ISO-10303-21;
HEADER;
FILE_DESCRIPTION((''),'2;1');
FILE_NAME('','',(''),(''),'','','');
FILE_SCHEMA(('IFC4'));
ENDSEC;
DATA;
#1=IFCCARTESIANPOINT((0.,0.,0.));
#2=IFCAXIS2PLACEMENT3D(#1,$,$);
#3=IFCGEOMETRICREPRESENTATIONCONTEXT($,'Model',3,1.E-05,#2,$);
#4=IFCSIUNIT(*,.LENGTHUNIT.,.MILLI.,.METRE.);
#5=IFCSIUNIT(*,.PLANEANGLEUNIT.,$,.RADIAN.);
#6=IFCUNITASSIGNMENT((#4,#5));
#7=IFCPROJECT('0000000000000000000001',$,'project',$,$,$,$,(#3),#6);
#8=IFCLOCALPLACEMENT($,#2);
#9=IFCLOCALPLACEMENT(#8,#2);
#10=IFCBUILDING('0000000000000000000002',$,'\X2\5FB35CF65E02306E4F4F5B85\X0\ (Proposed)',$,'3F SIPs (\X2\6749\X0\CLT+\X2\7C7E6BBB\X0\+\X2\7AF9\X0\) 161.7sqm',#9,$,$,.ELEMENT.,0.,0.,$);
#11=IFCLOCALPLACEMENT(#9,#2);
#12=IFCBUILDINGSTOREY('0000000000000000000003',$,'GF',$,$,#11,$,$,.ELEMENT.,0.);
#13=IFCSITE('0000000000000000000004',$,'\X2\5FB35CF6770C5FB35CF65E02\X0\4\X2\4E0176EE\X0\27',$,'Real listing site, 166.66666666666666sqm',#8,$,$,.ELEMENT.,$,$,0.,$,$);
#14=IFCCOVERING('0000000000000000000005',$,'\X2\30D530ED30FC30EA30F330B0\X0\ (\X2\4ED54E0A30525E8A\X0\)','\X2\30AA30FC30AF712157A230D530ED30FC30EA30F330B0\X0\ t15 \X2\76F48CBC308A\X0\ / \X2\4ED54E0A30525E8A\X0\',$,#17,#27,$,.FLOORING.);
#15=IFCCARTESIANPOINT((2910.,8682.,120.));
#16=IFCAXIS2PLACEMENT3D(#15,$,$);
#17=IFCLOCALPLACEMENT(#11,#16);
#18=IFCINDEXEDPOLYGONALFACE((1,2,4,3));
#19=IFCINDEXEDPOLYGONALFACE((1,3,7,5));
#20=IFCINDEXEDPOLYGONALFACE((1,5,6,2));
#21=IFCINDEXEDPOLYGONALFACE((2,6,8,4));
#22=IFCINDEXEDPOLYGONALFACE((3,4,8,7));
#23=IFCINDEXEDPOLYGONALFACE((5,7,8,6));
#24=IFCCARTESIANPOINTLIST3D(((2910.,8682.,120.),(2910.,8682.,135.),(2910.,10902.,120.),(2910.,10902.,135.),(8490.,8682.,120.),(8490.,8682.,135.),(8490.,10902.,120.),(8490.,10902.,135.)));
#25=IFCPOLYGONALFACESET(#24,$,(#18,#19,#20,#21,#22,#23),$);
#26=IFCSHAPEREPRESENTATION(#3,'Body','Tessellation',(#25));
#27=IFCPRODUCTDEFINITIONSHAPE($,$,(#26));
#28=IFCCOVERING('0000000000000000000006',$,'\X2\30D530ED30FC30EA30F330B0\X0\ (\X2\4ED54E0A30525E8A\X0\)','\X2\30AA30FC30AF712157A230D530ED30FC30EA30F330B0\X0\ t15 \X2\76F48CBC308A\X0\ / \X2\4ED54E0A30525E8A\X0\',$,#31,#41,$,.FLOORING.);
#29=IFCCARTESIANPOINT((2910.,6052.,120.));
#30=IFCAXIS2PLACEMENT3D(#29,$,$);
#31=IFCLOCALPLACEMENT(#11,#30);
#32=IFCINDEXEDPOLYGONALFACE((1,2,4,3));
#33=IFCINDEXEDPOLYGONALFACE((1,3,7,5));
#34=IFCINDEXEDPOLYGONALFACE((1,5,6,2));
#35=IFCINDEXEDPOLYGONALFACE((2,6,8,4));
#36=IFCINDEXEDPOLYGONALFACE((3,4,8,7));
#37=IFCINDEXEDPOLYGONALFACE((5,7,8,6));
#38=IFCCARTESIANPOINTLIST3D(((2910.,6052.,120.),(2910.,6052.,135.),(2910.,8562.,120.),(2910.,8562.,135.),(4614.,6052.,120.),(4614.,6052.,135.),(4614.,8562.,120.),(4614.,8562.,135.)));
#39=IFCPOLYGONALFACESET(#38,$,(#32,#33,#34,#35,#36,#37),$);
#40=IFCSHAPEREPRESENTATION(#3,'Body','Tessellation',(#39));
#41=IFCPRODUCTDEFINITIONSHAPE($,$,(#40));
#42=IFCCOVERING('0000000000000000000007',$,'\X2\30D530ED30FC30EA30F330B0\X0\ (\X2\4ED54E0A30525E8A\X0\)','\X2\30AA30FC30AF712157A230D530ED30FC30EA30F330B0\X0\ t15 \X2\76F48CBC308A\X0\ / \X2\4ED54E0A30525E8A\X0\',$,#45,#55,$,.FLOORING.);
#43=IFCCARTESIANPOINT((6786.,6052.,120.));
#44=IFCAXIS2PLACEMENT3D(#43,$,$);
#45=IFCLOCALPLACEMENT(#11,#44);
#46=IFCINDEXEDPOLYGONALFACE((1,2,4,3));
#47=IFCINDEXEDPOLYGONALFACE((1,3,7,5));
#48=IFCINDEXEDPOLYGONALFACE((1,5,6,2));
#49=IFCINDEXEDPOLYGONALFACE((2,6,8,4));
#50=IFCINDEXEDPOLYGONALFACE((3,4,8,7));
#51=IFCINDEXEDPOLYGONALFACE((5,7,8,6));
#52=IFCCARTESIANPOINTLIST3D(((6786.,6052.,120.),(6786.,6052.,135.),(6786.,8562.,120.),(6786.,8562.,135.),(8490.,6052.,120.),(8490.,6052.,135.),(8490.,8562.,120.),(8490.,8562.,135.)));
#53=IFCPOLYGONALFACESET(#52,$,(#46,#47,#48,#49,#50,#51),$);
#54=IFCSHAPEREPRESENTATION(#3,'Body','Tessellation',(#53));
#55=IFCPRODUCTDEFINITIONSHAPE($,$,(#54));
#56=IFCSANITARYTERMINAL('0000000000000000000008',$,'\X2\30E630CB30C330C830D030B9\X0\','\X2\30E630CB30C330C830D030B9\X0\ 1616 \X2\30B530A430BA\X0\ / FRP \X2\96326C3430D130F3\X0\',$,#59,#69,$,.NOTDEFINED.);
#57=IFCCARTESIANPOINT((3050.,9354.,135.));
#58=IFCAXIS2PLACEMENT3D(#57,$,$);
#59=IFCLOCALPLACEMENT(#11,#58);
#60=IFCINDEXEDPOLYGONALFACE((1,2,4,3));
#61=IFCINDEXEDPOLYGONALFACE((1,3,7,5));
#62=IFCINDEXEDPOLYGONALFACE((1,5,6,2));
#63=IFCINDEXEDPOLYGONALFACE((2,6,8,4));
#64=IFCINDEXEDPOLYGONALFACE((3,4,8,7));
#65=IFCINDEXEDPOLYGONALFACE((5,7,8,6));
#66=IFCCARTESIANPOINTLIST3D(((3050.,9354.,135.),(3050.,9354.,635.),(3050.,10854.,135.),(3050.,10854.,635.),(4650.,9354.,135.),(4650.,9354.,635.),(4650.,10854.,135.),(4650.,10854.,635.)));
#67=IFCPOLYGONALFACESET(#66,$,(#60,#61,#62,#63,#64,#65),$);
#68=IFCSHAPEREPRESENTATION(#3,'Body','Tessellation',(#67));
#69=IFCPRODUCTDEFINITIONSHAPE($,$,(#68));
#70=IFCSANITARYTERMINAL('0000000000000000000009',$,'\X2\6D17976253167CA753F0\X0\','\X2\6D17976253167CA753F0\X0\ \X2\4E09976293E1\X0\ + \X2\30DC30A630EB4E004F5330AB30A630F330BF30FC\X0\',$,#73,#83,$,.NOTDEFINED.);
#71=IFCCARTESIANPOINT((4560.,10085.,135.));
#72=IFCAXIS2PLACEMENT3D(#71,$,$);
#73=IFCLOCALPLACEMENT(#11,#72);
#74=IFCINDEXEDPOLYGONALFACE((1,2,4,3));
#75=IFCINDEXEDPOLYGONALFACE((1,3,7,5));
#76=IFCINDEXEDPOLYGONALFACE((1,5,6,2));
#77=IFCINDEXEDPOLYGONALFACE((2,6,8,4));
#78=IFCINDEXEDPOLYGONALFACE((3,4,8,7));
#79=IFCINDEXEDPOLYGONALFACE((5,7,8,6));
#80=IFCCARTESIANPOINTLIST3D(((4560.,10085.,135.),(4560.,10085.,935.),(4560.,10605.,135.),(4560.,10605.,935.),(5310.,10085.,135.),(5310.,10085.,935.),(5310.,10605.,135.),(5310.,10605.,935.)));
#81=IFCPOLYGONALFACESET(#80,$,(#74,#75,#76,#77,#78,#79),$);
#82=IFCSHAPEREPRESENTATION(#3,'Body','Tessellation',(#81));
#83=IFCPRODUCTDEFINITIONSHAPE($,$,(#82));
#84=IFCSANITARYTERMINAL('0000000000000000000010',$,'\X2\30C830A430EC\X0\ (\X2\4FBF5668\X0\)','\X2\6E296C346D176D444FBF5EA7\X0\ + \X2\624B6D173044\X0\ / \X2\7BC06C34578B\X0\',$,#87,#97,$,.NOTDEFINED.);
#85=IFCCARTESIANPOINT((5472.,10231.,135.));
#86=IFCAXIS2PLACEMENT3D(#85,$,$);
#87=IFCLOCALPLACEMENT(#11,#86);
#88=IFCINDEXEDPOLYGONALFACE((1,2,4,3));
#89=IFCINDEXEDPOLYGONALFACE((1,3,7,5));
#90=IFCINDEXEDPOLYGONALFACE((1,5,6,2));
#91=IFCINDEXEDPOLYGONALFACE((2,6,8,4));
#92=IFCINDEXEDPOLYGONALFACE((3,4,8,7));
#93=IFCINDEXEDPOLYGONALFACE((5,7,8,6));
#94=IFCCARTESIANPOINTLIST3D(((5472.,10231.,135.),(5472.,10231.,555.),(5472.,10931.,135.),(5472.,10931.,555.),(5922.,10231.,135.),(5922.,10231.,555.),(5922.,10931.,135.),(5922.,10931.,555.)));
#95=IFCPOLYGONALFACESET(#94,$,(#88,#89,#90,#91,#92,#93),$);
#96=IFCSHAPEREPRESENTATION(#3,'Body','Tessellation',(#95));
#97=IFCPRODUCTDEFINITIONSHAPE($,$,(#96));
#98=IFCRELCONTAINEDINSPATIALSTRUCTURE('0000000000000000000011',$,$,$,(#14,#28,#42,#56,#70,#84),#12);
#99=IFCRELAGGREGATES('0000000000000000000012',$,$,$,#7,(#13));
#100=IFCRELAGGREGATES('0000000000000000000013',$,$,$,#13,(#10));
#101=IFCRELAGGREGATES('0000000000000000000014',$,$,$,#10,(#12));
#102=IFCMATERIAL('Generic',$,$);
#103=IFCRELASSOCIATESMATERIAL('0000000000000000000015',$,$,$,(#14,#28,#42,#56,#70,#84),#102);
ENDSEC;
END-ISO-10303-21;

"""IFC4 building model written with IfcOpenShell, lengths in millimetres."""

from ifc_helpers import new_model, si_unit, frame, frame_2d, origin, place, context, project, spatial, rectangle, extrude, material, element, save


model = new_model("IFC4")

# Units and contexts
model_context = context("Model", 3, precision=1e-05, world=origin())
ifc_project = project(units=[si_unit("LENGTHUNIT", "METRE", prefix="MILLI"), si_unit("PLANEANGLEUNIT", "RADIAN")], contexts=[model_context])

# Site, building, storey
site_placement = place(None, origin())
site = spatial("IfcSite", under=ifc_project, at=site_placement, Name="徳島県徳島市4丁目27", ObjectType="Real listing site, 166.66666666666666sqm", CompositionType="ELEMENT", RefElevation=0.0)
building_placement = place(site_placement, origin())
building = spatial("IfcBuilding", under=site, at=building_placement, Name="徳島市の住宅 (Proposed)", ObjectType="3F SIPs (杉CLT+籾殻+竹) 161.7sqm", CompositionType="ELEMENT", ElevationOfRefHeight=0.0, ElevationOfTerrain=0.0)
storey_placement = place(building_placement, origin())
storey = spatial("IfcBuildingStorey", under=building, at=storey_placement, Name="GF", CompositionType="ELEMENT", Elevation=0.0)

# Coverings
ifc_material_1 = material(Name="Generic")
covering_1_placement = place(storey_placement, frame((2910.0, 8682.0, 120.0)))
element("IfcCovering", 1, at=covering_1_placement, inside=storey, material=ifc_material_1, Name="フローリング (仕上げ床)", Description="オーク無垢フローリング t15 直貼り / 仕上げ床", PredefinedType="FLOORING", context=model_context, shape_type="SweptSolid", body=[
    extrude(rectangle(XDim=5580.0, YDim=2220.0, at=frame_2d((2790.0, 1110.0))), frame((2910.0, 8682.0, 120.0)), (0.0, 0.0, 1.0), 15.0),
])
covering_2_placement = place(storey_placement, frame((2910.0, 6052.0, 120.0)))
element("IfcCovering", 2, at=covering_2_placement, inside=storey, material=ifc_material_1, Name="フローリング (仕上げ床)", Description="オーク無垢フローリング t15 直貼り / 仕上げ床", PredefinedType="FLOORING", context=model_context, shape_type="SweptSolid", body=[
    extrude(rectangle(XDim=1704.0, YDim=2510.0, at=frame_2d((852.0, 1255.0))), frame((2910.0, 6052.0, 120.0)), (0.0, 0.0, 1.0), 15.0),
])
covering_3_placement = place(storey_placement, frame((6786.0, 6052.0, 120.0)))
element("IfcCovering", 3, at=covering_3_placement, inside=storey, material=ifc_material_1, Name="フローリング (仕上げ床)", Description="オーク無垢フローリング t15 直貼り / 仕上げ床", PredefinedType="FLOORING", context=model_context, shape_type="SweptSolid", body=[
    extrude(rectangle(XDim=1704.0, YDim=2510.0, at=frame_2d((852.0, 1255.0))), frame((6786.0, 6052.0, 120.0)), (0.0, 0.0, 1.0), 15.0),
])

# Sanitary terminals
sanitary_terminal_1_placement = place(storey_placement, frame((3050.0, 9354.0, 135.0)))
element("IfcSanitaryTerminal", 4, at=sanitary_terminal_1_placement, inside=storey, material=ifc_material_1, Name="ユニットバス", Description="ユニットバス 1616 サイズ / FRP 防水パン", PredefinedType="NOTDEFINED", context=model_context, shape_type="SweptSolid", body=[
    extrude(rectangle(XDim=1600.0, YDim=1500.0, at=frame_2d((800.0, 750.0))), frame((3050.0, 9354.0, 135.0)), (0.0, 0.0, 1.0), 500.0),
])
sanitary_terminal_2_placement = place(storey_placement, frame((4560.0, 10085.0, 135.0)))
element("IfcSanitaryTerminal", 5, at=sanitary_terminal_2_placement, inside=storey, material=ifc_material_1, Name="洗面化粧台", Description="洗面化粧台 三面鏡 + ボウル一体カウンター", PredefinedType="NOTDEFINED", context=model_context, shape_type="SweptSolid", body=[
    extrude(rectangle(XDim=750.0, YDim=520.0, at=frame_2d((375.0, 260.0))), frame((4560.0, 10085.0, 135.0)), (0.0, 0.0, 1.0), 800.0),
])
sanitary_terminal_3_placement = place(storey_placement, frame((5472.0, 10231.0, 135.0)))
element("IfcSanitaryTerminal", 6, at=sanitary_terminal_3_placement, inside=storey, material=ifc_material_1, Name="トイレ (便器)", Description="温水洗浄便座 + 手洗い / 節水型", PredefinedType="NOTDEFINED", context=model_context, shape_type="SweptSolid", body=[
    extrude(rectangle(XDim=450.0, YDim=700.0, at=frame_2d((225.0, 350.0))), frame((5472.0, 10231.0, 135.0)), (0.0, 0.0, 1.0), 420.0),
])

save(model, "model.ifc")
